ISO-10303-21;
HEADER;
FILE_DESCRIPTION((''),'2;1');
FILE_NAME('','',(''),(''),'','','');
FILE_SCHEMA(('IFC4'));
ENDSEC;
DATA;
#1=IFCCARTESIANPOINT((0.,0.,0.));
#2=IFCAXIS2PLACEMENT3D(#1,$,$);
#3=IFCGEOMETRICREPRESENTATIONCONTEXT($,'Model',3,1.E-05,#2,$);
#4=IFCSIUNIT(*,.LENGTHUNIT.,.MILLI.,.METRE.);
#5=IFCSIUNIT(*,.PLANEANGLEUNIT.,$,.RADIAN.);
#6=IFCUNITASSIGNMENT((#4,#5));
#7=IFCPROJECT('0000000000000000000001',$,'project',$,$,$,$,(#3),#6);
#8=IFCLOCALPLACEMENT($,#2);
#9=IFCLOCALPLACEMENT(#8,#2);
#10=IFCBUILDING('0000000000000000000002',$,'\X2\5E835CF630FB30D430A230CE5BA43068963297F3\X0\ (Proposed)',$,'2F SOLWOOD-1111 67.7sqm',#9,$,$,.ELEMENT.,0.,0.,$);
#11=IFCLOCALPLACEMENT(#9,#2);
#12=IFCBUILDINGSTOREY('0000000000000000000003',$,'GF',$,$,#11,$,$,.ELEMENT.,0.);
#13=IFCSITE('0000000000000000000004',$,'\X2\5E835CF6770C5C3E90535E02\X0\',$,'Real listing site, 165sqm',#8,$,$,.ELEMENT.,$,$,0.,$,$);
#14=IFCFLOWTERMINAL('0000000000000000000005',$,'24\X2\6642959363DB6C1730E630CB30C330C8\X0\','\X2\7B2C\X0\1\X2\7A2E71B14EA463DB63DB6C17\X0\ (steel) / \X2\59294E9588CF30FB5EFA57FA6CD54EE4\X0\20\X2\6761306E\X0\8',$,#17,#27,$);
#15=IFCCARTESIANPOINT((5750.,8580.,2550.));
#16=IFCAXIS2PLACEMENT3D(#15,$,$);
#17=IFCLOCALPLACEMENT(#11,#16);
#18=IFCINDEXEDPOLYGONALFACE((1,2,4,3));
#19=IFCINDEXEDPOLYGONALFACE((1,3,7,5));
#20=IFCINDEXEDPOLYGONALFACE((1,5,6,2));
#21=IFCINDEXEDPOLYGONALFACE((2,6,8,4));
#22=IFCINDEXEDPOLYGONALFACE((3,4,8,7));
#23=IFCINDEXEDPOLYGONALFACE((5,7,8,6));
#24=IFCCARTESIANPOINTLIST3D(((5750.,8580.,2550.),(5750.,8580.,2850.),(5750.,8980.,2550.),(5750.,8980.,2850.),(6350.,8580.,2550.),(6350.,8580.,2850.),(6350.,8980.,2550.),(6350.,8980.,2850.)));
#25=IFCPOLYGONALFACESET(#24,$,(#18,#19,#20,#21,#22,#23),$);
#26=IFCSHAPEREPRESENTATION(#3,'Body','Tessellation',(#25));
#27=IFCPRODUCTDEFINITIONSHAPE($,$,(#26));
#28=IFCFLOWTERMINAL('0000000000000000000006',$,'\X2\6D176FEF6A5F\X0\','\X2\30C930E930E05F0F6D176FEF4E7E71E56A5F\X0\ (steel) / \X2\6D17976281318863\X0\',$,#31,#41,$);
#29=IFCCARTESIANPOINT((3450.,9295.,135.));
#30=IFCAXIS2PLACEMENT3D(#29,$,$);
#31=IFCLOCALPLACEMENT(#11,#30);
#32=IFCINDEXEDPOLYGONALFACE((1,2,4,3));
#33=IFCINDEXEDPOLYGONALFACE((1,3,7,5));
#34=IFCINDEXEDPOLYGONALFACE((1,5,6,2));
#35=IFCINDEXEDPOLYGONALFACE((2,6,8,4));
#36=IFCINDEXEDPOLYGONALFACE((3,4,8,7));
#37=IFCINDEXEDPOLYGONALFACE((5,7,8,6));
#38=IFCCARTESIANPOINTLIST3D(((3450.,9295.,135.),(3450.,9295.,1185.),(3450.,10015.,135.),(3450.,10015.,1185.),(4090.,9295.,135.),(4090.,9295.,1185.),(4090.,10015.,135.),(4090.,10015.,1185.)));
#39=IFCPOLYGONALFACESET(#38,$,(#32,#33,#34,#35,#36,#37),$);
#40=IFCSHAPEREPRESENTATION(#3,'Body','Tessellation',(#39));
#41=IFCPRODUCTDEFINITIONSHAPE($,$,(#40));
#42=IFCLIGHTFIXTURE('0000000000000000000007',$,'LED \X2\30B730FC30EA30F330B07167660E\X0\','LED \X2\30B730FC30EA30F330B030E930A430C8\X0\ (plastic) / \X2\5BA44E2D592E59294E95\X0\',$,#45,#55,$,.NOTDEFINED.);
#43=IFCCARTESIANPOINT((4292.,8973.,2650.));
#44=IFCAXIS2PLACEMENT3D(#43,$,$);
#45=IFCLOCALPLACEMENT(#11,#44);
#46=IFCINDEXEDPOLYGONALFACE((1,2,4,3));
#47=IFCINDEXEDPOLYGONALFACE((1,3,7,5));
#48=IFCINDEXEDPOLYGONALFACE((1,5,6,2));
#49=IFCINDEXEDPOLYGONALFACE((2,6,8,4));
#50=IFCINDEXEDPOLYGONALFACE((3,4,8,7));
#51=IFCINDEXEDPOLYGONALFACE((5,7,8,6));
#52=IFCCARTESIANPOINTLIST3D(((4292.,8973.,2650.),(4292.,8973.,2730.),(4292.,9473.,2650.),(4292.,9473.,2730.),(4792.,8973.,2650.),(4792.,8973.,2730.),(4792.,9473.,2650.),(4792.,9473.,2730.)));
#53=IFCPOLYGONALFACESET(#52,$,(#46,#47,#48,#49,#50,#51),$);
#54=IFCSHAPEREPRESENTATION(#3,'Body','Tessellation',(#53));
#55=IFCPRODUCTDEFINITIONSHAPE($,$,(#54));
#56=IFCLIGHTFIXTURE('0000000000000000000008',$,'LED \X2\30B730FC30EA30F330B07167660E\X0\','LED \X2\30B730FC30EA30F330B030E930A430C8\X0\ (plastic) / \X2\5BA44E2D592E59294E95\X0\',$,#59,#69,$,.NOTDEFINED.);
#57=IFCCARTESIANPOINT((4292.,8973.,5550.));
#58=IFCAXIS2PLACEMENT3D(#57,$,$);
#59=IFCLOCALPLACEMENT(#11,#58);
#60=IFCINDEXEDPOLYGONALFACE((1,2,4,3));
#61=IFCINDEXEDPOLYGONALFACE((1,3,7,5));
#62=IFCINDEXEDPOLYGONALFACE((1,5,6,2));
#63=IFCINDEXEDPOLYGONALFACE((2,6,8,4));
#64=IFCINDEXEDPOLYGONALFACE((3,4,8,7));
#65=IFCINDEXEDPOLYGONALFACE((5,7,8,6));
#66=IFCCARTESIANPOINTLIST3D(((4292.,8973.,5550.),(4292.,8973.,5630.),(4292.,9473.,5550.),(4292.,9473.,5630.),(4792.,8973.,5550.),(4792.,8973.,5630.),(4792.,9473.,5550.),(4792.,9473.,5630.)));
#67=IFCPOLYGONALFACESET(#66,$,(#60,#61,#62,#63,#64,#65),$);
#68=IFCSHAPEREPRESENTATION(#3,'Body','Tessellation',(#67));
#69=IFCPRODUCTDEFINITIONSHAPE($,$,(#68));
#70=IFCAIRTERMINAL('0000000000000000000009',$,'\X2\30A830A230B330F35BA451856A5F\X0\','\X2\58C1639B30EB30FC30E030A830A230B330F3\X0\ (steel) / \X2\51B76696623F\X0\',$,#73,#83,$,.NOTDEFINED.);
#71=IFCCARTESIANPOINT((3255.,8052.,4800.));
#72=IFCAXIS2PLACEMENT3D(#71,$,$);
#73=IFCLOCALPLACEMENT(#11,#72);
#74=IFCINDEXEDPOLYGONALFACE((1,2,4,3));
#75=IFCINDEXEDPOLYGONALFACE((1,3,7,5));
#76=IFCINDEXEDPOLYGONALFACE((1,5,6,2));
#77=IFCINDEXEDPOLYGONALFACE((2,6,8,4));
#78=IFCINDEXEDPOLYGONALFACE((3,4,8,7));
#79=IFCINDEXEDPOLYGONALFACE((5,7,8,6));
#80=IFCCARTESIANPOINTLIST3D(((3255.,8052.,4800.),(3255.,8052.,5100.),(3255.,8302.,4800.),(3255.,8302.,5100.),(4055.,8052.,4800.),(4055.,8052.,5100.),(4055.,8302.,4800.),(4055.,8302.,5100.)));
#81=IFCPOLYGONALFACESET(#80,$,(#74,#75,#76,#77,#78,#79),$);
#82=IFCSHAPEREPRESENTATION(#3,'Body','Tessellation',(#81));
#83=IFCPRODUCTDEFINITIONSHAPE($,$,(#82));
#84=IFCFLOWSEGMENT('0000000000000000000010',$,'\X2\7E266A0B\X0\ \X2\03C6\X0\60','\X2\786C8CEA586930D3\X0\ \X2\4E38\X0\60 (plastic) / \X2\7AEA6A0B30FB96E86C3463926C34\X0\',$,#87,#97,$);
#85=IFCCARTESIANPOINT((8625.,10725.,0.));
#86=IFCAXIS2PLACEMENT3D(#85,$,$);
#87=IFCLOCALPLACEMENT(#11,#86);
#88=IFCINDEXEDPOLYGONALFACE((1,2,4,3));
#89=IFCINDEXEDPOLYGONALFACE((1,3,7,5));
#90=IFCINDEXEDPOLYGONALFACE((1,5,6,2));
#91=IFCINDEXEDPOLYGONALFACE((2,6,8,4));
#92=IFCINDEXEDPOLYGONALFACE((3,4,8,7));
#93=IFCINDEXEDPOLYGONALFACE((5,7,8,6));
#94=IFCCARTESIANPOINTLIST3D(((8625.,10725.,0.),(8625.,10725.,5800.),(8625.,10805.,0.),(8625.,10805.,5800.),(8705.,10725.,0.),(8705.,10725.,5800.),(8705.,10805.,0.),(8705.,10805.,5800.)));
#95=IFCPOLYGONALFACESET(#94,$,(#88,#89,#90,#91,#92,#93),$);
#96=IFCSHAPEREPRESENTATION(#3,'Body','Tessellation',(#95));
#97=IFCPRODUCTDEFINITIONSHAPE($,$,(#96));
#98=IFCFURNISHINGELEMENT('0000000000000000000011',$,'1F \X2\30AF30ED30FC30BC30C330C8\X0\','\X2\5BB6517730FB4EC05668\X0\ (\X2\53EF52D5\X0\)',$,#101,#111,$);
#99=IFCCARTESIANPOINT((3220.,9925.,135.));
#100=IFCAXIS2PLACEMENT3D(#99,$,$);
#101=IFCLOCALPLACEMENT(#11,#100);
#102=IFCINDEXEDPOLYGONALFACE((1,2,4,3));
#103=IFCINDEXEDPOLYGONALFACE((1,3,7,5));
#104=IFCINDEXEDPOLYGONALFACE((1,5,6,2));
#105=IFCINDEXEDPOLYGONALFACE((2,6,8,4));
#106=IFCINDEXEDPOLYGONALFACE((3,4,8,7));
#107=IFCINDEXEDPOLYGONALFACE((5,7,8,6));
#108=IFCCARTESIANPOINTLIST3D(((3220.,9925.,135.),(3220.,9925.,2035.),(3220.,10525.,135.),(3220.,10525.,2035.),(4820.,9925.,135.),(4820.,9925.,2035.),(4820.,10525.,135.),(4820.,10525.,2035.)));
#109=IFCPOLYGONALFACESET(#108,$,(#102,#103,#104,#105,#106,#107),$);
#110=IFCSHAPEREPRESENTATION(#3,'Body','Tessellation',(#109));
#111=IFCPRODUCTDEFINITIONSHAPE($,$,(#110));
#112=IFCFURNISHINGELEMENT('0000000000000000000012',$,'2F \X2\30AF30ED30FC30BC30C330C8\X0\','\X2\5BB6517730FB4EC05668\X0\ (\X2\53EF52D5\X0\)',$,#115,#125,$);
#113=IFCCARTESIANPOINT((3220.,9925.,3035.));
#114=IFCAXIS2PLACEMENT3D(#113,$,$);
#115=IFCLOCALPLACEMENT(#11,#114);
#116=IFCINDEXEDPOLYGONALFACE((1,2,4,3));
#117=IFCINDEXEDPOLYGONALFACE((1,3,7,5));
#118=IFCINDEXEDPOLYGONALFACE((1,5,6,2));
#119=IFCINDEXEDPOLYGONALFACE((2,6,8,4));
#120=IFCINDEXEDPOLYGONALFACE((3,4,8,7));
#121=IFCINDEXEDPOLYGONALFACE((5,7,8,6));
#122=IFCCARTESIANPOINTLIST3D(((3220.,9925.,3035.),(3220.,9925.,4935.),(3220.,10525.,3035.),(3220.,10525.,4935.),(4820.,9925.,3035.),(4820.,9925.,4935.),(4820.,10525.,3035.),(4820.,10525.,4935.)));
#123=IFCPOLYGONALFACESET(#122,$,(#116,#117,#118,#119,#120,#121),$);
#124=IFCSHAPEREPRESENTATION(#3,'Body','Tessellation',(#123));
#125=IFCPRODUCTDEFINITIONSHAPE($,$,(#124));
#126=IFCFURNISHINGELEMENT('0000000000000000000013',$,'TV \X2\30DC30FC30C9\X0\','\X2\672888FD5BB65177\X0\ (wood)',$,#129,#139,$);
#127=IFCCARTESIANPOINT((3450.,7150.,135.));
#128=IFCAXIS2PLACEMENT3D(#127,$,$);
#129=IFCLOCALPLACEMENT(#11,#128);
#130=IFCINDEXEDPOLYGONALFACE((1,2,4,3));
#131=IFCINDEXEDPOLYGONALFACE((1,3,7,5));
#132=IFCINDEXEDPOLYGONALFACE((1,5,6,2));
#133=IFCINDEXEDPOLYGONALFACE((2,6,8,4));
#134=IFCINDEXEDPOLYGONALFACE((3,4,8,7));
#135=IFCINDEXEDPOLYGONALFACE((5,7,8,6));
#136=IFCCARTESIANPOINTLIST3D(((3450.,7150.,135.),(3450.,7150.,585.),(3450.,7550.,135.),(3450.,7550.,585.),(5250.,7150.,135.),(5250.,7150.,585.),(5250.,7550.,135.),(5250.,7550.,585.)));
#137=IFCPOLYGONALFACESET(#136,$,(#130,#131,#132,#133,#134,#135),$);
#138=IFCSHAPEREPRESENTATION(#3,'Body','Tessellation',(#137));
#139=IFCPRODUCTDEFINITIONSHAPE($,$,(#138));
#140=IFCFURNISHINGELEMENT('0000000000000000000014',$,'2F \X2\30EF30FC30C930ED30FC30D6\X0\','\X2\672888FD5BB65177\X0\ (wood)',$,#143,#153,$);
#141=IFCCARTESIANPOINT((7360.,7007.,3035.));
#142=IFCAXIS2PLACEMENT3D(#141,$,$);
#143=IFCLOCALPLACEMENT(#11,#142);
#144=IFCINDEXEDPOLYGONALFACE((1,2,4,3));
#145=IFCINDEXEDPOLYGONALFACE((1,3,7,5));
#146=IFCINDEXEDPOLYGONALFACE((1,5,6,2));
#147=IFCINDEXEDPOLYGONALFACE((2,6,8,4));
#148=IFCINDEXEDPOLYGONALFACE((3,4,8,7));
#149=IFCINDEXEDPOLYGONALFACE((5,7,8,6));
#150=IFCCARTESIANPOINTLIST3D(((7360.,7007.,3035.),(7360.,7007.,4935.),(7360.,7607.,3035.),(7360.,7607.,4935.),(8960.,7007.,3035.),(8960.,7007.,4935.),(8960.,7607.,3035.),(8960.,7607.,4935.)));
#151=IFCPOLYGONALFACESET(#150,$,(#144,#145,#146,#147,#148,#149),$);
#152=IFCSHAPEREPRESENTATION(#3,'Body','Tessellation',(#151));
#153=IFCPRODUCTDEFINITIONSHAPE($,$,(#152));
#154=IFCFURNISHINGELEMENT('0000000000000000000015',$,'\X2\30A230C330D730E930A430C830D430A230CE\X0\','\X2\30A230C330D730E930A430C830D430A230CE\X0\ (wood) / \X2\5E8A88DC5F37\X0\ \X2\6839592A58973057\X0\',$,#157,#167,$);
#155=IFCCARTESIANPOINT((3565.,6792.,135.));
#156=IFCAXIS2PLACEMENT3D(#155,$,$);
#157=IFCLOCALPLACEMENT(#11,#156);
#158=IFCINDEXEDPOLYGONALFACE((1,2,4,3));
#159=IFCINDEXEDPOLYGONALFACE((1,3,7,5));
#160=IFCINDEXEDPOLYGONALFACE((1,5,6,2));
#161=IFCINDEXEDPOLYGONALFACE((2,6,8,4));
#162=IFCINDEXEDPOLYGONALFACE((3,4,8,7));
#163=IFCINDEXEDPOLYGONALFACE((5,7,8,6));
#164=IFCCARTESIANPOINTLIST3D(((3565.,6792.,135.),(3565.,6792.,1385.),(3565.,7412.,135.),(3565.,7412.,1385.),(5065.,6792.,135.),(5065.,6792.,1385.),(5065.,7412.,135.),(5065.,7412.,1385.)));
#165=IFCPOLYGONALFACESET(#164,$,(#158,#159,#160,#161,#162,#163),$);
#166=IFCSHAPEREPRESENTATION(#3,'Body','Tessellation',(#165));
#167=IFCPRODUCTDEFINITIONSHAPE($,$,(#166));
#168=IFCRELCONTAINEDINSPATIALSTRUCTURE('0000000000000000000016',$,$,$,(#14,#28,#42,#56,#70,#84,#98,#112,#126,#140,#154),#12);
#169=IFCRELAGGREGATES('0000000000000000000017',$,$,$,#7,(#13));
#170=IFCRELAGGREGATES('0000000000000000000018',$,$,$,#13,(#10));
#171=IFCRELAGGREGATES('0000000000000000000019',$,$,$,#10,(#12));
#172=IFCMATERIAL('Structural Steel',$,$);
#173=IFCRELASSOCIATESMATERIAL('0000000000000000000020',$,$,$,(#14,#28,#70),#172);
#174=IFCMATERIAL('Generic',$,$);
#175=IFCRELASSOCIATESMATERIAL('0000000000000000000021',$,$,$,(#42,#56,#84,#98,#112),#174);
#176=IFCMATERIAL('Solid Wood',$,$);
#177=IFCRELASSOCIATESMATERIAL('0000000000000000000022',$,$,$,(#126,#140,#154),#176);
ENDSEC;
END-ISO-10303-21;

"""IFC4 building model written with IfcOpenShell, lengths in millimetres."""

from ifc_helpers import new_model, si_unit, frame, frame_2d, origin, place, context, project, spatial, rectangle, extrude, material, element, save


model = new_model("IFC4")

# Units and contexts
model_context = context("Model", 3, precision=1e-05, world=origin())
ifc_project = project(units=[si_unit("LENGTHUNIT", "METRE", prefix="MILLI"), si_unit("PLANEANGLEUNIT", "RADIAN")], contexts=[model_context])

# Site, building, storey
site_placement = place(None, origin())
site = spatial("IfcSite", under=ifc_project, at=site_placement, Name="広島県尾道市", ObjectType="Real listing site, 165sqm", CompositionType="ELEMENT", RefElevation=0.0)
building_placement = place(site_placement, origin())
building = spatial("IfcBuilding", under=site, at=building_placement, Name="広島・ピアノ室と防音 (Proposed)", ObjectType="2F SOLWOOD-1111 67.7sqm", CompositionType="ELEMENT", ElevationOfRefHeight=0.0, ElevationOfTerrain=0.0)
storey_placement = place(building_placement, origin())
storey = spatial("IfcBuildingStorey", under=building, at=storey_placement, Name="GF", CompositionType="ELEMENT", Elevation=0.0)

# Shared definitions
ifc_material_1 = material(Name="Solid Wood")

# Shared definitions
ifc_material_2 = material(Name="Generic")

# Flow terminals
ifc_material_3 = material(Name="Structural Steel")
flow_terminal_1_placement = place(storey_placement, frame((5750.0, 8580.0, 2550.0)))
element("IfcFlowTerminal", 1, at=flow_terminal_1_placement, inside=storey, material=ifc_material_3, Name="24時間換気ユニット", Description="第1種熱交換換気 (steel) / 天井裏・建基法令20条の8", context=model_context, shape_type="SweptSolid", body=[
    extrude(rectangle(XDim=600.0, YDim=400.0, at=frame_2d((300.0, 200.0))), frame((5750.0, 8580.0, 2550.0)), (0.0, 0.0, 1.0), 300.0),
])
flow_terminal_2_placement = place(storey_placement, frame((3450.0, 9295.0, 135.0)))
element("IfcFlowTerminal", 2, at=flow_terminal_2_placement, inside=storey, material=ifc_material_3, Name="洗濯機", Description="ドラム式洗濯乾燥機 (steel) / 洗面脱衣", context=model_context, shape_type="SweptSolid", body=[
    extrude(rectangle(XDim=640.0, YDim=720.0, at=frame_2d((320.0, 360.0))), frame((3450.0, 9295.0, 135.0)), (0.0, 0.0, 1.0), 1050.0),
])

# Light fixtures
light_fixture_1_placement = place(storey_placement, frame((4292.0, 8973.0, 2650.0)))
element("IfcLightFixture", 3, at=light_fixture_1_placement, inside=storey, material=ifc_material_2, Name="LED シーリング照明", Description="LED シーリングライト (plastic) / 室中央天井", PredefinedType="NOTDEFINED", context=model_context, shape_type="SweptSolid", body=[
    extrude(rectangle(XDim=500.0, YDim=500.0, at=frame_2d((250.0, 250.0))), frame((4292.0, 8973.0, 2650.0)), (0.0, 0.0, 1.0), 80.0),
])
light_fixture_2_placement = place(storey_placement, frame((4292.0, 8973.0, 5550.0)))
element("IfcLightFixture", 4, at=light_fixture_2_placement, inside=storey, material=ifc_material_2, Name="LED シーリング照明", Description="LED シーリングライト (plastic) / 室中央天井", PredefinedType="NOTDEFINED", context=model_context, shape_type="SweptSolid", body=[
    extrude(rectangle(XDim=500.0, YDim=500.0, at=frame_2d((250.0, 250.0))), frame((4292.0, 8973.0, 5550.0)), (0.0, 0.0, 1.0), 80.0),
])

# Air terminal
air_terminal_placement = place(storey_placement, frame((3255.0, 8052.0, 4800.0)))
element("IfcAirTerminal", 5, at=air_terminal_placement, inside=storey, material=ifc_material_3, Name="エアコン室内機", Description="壁掛ルームエアコン (steel) / 冷暖房", PredefinedType="NOTDEFINED", context=model_context, shape_type="SweptSolid", body=[
    extrude(rectangle(XDim=800.0, YDim=250.0, at=frame_2d((400.0, 125.0))), frame((3255.0, 8052.0, 4800.0)), (0.0, 0.0, 1.0), 300.0),
])

# Flow segment
flow_segment_placement = place(storey_placement, frame((8625.0, 10725.0, 0.0)))
element("IfcFlowSegment", 6, at=flow_segment_placement, inside=storey, material=ifc_material_2, Name="縦樋 φ60", Description="硬質塩ビ 丸60 (plastic) / 竪樋・雨水排水", context=model_context, shape_type="SweptSolid", body=[
    extrude(rectangle(XDim=80.0, YDim=80.0, at=frame_2d((40.0, 40.0))), frame((8625.0, 10725.0, 0.0)), (0.0, 0.0, 1.0), 5800.0),
])

# Furnishing elements
furnishing_1_placement = place(storey_placement, frame((3220.0, 9925.0, 135.0)))
element("IfcFurnishingElement", 7, at=furnishing_1_placement, inside=storey, material=ifc_material_2, Name="1F クローゼット", Description="家具・什器 (可動)", context=model_context, shape_type="SweptSolid", body=[
    extrude(rectangle(XDim=1600.0, YDim=600.0, at=frame_2d((800.0, 300.0))), frame((3220.0, 9925.0, 135.0)), (0.0, 0.0, 1.0), 1900.0),
])
furnishing_2_placement = place(storey_placement, frame((3220.0, 9925.0, 3035.0)))
element("IfcFurnishingElement", 8, at=furnishing_2_placement, inside=storey, material=ifc_material_2, Name="2F クローゼット", Description="家具・什器 (可動)", context=model_context, shape_type="SweptSolid", body=[
    extrude(rectangle(XDim=1600.0, YDim=600.0, at=frame_2d((800.0, 300.0))), frame((3220.0, 9925.0, 3035.0)), (0.0, 0.0, 1.0), 1900.0),
])
furnishing_3_placement = place(storey_placement, frame((3450.0, 7150.0, 135.0)))
element("IfcFurnishingElement", 9, at=furnishing_3_placement, inside=storey, material=ifc_material_1, Name="TV ボード", Description="木製家具 (wood)", context=model_context, shape_type="SweptSolid", body=[
    extrude(rectangle(XDim=1800.0, YDim=400.0, at=frame_2d((900.0, 200.0))), frame((3450.0, 7150.0, 135.0)), (0.0, 0.0, 1.0), 450.0),
])
furnishing_4_placement = place(storey_placement, frame((7360.0, 7007.0, 3035.0)))
element("IfcFurnishingElement", 10, at=furnishing_4_placement, inside=storey, material=ifc_material_1, Name="2F ワードローブ", Description="木製家具 (wood)", context=model_context, shape_type="SweptSolid", body=[
    extrude(rectangle(XDim=1600.0, YDim=600.0, at=frame_2d((800.0, 300.0))), frame((7360.0, 7007.0, 3035.0)), (0.0, 0.0, 1.0), 1900.0),
])
furnishing_5_placement = place(storey_placement, frame((3565.0, 6792.0, 135.0)))
element("IfcFurnishingElement", 11, at=furnishing_5_placement, inside=storey, material=ifc_material_1, Name="アップライトピアノ", Description="アップライトピアノ (wood) / 床補強 根太増し", context=model_context, shape_type="SweptSolid", body=[
    extrude(rectangle(XDim=1500.0, YDim=620.0, at=frame_2d((750.0, 310.0))), frame((3565.0, 6792.0, 135.0)), (0.0, 0.0, 1.0), 1250.0),
])

save(model, "model.ifc")
